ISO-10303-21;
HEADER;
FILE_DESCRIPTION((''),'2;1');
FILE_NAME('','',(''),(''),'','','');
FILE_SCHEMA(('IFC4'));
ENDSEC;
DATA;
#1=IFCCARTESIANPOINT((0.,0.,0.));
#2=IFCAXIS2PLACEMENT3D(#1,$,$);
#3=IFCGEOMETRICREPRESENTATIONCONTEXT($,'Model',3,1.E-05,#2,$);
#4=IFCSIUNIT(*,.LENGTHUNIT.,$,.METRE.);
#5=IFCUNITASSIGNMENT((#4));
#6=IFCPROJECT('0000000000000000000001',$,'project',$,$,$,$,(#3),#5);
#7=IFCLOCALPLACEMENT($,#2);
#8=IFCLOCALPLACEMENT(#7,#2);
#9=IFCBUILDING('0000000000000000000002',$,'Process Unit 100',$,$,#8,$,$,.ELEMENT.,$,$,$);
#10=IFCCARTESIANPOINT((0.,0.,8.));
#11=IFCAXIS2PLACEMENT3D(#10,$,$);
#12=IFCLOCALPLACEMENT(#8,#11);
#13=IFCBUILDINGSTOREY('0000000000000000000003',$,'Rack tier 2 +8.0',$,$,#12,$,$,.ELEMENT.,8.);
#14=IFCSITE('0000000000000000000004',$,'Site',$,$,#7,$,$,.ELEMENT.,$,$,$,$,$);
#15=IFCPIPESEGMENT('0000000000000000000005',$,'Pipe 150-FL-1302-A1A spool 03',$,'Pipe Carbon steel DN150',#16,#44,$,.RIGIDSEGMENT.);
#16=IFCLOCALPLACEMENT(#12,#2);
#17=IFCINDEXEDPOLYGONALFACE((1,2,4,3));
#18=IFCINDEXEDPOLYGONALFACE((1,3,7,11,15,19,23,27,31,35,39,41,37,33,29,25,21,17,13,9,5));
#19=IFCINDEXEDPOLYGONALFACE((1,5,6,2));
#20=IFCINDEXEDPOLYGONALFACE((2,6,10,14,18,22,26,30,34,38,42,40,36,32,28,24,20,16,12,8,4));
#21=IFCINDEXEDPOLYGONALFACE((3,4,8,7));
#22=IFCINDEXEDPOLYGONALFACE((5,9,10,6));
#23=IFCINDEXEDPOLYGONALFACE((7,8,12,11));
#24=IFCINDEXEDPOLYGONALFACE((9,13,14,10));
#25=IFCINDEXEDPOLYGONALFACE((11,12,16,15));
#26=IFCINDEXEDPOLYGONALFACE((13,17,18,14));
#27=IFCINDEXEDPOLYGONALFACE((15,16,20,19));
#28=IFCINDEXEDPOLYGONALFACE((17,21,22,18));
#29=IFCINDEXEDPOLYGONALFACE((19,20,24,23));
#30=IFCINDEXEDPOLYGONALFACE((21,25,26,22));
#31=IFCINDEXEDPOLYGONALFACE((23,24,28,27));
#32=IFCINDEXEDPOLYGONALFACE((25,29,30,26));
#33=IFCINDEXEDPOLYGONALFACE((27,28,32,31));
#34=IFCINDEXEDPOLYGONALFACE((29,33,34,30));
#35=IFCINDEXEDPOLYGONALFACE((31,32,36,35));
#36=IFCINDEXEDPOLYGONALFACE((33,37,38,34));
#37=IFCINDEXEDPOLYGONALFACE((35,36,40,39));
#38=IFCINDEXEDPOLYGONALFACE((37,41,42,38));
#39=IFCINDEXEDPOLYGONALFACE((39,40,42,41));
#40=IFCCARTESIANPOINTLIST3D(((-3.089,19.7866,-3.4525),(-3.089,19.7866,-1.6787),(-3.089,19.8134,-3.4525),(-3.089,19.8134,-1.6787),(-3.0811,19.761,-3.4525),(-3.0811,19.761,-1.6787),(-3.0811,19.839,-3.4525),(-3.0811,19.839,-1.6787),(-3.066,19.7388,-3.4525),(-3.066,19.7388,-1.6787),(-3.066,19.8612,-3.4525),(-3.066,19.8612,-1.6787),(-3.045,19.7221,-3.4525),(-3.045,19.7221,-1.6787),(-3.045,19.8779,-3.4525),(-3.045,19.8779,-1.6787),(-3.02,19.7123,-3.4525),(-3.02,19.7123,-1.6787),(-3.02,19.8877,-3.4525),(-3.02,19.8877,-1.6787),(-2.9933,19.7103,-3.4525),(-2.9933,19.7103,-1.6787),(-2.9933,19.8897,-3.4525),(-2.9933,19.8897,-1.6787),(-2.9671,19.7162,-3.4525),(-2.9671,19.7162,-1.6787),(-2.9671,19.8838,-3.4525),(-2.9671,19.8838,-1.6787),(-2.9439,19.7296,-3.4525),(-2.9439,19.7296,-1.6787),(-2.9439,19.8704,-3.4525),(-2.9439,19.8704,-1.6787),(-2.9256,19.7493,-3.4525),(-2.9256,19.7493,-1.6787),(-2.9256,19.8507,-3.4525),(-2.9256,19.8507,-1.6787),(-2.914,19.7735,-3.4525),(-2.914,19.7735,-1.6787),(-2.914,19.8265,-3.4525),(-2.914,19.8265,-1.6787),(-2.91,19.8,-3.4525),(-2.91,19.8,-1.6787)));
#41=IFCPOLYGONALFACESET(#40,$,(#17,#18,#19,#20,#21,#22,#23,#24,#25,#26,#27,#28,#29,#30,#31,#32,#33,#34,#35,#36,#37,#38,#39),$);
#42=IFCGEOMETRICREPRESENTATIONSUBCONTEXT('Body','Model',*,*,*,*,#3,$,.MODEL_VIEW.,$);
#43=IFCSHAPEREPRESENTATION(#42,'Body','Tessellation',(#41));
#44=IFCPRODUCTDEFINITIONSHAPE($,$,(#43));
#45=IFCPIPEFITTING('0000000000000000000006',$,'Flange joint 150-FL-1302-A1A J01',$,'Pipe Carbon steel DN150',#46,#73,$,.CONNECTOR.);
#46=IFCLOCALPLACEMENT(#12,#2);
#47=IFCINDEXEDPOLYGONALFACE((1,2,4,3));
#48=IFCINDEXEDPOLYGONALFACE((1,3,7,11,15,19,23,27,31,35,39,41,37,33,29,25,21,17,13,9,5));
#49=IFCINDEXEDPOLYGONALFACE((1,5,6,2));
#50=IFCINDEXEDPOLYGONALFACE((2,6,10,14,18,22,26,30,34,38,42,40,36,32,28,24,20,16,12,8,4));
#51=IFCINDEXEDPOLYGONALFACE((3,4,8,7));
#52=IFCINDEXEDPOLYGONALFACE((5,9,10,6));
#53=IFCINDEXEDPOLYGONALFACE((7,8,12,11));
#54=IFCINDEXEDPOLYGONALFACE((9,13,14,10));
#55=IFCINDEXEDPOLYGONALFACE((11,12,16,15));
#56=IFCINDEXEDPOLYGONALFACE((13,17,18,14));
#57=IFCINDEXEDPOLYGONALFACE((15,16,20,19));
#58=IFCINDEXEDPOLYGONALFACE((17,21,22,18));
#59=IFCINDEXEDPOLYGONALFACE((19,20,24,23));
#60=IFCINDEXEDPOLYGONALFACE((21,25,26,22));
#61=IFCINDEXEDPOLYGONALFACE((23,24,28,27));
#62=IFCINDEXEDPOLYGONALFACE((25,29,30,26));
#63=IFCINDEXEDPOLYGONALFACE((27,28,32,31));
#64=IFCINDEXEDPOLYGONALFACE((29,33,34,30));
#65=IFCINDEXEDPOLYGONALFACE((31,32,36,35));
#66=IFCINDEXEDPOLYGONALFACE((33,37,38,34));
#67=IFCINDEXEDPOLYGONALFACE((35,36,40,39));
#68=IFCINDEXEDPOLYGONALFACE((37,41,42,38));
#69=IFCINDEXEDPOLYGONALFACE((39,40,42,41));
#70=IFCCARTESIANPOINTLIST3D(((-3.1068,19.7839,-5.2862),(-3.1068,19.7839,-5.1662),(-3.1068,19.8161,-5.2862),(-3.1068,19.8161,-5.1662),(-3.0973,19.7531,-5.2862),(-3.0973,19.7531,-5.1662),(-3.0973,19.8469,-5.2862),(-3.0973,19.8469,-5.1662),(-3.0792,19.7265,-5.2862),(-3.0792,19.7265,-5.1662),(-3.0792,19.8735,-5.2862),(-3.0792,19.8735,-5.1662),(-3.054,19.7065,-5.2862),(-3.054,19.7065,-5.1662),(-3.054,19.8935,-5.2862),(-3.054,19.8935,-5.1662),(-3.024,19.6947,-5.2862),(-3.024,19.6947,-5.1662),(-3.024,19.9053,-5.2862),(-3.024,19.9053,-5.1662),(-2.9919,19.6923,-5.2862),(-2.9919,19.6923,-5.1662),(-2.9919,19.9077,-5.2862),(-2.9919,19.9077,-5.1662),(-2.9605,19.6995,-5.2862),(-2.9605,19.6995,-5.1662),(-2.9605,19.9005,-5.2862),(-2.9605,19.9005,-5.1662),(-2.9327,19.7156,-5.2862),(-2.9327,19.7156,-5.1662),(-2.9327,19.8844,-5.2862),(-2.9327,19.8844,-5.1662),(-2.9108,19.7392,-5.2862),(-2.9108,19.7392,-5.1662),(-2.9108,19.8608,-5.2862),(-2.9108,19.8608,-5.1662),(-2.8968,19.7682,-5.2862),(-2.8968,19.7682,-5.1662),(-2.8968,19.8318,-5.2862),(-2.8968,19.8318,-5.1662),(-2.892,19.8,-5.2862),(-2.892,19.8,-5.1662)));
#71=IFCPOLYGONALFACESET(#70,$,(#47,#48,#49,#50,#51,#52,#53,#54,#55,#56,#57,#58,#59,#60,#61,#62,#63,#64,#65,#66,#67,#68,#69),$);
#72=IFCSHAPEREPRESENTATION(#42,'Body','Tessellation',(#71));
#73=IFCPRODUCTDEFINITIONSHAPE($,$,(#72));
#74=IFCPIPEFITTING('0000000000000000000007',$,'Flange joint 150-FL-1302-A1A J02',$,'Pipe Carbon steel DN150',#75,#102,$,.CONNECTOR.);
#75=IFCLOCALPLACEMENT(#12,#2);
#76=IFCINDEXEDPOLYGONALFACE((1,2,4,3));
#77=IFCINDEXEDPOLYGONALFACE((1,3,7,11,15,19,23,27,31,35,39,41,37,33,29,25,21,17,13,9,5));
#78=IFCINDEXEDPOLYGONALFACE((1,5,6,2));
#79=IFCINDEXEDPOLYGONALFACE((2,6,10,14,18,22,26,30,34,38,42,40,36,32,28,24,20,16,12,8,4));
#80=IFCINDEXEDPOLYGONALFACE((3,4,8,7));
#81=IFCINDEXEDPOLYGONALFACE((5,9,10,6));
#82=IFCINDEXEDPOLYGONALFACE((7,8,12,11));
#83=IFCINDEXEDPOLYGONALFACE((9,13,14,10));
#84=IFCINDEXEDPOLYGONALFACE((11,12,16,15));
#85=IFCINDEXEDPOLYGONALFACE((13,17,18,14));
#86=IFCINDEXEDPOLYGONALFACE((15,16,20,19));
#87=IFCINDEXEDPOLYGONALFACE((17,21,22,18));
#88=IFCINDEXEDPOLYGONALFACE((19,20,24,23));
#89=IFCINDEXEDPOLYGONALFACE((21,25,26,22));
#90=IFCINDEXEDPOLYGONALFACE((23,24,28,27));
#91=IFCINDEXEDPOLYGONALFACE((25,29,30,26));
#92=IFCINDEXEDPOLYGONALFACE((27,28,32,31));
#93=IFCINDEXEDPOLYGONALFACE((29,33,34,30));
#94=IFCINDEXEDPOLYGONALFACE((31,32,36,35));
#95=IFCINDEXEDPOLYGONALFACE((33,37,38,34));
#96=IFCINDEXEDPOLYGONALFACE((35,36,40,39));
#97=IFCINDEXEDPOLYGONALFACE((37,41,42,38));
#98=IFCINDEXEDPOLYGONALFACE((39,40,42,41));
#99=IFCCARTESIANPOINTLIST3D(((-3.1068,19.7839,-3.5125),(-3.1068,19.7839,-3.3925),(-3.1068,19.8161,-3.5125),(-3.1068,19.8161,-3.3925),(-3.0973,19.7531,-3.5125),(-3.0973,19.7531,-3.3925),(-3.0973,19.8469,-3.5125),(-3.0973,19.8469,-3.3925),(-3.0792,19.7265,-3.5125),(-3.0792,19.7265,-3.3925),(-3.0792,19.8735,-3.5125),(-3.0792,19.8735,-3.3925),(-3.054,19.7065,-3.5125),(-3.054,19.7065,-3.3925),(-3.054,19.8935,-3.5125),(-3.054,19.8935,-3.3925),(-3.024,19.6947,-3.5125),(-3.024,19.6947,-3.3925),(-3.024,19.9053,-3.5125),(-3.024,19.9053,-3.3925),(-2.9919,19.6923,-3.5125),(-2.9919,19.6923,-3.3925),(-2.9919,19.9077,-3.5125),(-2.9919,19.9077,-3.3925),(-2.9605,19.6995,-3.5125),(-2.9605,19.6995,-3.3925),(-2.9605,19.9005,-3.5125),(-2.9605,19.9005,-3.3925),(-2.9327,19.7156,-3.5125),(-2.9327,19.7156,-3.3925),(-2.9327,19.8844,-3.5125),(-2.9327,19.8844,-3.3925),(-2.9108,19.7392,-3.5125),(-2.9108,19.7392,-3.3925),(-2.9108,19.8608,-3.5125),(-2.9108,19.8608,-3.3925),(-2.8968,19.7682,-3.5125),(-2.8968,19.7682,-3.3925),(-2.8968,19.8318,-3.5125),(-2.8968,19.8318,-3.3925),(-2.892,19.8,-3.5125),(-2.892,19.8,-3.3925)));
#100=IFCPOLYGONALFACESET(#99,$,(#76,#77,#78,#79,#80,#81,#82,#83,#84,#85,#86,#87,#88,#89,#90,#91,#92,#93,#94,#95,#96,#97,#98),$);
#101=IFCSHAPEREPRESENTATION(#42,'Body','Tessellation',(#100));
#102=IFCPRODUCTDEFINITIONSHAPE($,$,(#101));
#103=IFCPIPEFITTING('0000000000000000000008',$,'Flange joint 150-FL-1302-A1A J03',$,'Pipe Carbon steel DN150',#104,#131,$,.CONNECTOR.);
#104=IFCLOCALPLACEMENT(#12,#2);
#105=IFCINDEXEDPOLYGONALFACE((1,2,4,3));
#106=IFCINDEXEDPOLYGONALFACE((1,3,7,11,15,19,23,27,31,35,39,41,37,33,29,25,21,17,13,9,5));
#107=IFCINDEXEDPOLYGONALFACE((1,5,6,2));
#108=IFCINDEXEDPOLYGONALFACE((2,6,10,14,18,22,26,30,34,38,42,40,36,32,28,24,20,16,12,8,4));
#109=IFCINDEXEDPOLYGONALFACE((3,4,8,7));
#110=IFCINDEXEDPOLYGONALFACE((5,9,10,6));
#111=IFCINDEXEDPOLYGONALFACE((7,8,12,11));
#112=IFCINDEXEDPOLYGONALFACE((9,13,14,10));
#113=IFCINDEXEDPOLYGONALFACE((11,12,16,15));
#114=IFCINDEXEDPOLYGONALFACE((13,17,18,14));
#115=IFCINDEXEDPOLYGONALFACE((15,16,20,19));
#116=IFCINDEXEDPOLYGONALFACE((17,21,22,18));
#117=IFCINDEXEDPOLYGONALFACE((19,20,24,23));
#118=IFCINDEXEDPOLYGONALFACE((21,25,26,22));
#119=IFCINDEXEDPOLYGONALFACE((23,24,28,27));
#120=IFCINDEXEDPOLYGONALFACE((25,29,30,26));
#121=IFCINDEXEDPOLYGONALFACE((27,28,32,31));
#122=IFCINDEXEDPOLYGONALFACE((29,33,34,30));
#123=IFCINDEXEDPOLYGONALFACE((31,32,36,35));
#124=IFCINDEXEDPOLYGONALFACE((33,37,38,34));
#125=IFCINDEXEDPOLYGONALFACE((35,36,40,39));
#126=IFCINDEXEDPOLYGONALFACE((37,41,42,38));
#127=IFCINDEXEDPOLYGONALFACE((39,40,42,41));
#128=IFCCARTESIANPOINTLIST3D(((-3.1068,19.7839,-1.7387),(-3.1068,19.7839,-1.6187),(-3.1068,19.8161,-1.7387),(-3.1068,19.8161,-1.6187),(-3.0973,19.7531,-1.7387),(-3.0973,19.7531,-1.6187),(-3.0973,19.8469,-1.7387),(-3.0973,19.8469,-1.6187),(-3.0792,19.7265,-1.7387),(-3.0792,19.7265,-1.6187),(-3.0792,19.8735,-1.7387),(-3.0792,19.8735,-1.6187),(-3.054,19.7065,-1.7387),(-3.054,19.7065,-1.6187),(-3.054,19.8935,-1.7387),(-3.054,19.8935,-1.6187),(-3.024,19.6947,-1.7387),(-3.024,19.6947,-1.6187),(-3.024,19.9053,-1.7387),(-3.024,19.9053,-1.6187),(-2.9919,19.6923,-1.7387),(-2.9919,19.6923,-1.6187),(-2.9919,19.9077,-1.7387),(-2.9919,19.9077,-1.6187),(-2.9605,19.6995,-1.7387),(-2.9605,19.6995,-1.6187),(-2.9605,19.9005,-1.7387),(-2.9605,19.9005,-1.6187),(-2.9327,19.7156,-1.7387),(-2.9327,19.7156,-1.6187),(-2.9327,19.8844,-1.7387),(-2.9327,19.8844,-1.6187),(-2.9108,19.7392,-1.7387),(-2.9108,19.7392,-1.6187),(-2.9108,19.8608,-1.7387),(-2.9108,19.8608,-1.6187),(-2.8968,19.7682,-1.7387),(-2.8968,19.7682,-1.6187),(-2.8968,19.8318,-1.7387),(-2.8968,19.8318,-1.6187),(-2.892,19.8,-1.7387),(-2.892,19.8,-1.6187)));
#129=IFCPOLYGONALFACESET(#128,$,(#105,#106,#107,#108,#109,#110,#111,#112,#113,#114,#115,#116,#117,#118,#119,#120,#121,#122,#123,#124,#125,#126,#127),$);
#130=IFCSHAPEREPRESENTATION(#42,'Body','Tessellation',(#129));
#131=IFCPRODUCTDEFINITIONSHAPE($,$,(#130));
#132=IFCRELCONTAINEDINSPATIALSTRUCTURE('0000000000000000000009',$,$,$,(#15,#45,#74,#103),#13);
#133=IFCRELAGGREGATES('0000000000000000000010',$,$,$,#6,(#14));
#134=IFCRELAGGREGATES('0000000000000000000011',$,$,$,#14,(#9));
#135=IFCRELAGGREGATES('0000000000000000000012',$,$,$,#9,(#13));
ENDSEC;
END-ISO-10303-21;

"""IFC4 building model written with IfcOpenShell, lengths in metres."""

from ifc_helpers import new_model, si_unit, frame, origin, place, context, subcontext, project, spatial, circle, extrude, element, save


model = new_model("IFC4")

# Units and contexts
model_context = context("Model", 3, precision=1e-05, world=origin())
body_context = subcontext(model_context, "Body", "Model", "MODEL_VIEW")
ifc_project = project(units=[si_unit("LENGTHUNIT", "METRE")], contexts=[model_context])

# Site, building, storey
site_placement = place(None, origin())
site = spatial("IfcSite", under=ifc_project, at=site_placement, Name="Site", CompositionType="ELEMENT")
building_placement = place(site_placement, origin())
building = spatial("IfcBuilding", under=site, at=building_placement, Name="Process Unit 100", CompositionType="ELEMENT")
storey_placement = place(building_placement, frame((0.0, 0.0, 8.0)))
storey = spatial("IfcBuildingStorey", under=building, at=storey_placement, Name="Rack tier 2 +8.0", CompositionType="ELEMENT", Elevation=8.0)

# Pipe segment
for number, where, z_axis, x_axis, name in (
    (1, (-3.0, 19.8, -3.4525), (0.0, 0.0, 1.0), (1.0, 0.0, 0.0), "Pipe 150-FL-1302-A1A spool 03"),
):
    element("IfcPipeSegment", number, at=place(storey_placement, frame(where, z_axis=z_axis, x_axis=x_axis)), inside=storey, Name=name, ObjectType="Pipe Carbon steel DN150", PredefinedType="RIGIDSEGMENT", context=body_context, shape_type="SweptSolid", body=[
        extrude(circle(Radius=0.09), origin(), (0.0, 0.0, 1.0), 1.7738),
    ])

# Pipe fittings
for number, where, z_axis, x_axis, name in (
    (2, (-3.0, 19.8, -5.2862), (0.0, 0.0, 1.0), (1.0, 0.0, 0.0), "Flange joint 150-FL-1302-A1A J01"),
    (3, (-3.0, 19.8, -3.5125), (0.0, 0.0, 1.0), (1.0, 0.0, 0.0), "Flange joint 150-FL-1302-A1A J02"),
    (4, (-3.0, 19.8, -1.7387), (0.0, 0.0, 1.0), (1.0, 0.0, 0.0), "Flange joint 150-FL-1302-A1A J03"),
):
    element("IfcPipeFitting", number, at=place(storey_placement, frame(where, z_axis=z_axis, x_axis=x_axis)), inside=storey, Name=name, ObjectType="Pipe Carbon steel DN150", PredefinedType="CONNECTOR", context=body_context, shape_type="SweptSolid", body=[
        extrude(circle(Radius=0.108), origin(), (0.0, 0.0, 1.0), 0.12),
    ])

save(model, "model.ifc")
